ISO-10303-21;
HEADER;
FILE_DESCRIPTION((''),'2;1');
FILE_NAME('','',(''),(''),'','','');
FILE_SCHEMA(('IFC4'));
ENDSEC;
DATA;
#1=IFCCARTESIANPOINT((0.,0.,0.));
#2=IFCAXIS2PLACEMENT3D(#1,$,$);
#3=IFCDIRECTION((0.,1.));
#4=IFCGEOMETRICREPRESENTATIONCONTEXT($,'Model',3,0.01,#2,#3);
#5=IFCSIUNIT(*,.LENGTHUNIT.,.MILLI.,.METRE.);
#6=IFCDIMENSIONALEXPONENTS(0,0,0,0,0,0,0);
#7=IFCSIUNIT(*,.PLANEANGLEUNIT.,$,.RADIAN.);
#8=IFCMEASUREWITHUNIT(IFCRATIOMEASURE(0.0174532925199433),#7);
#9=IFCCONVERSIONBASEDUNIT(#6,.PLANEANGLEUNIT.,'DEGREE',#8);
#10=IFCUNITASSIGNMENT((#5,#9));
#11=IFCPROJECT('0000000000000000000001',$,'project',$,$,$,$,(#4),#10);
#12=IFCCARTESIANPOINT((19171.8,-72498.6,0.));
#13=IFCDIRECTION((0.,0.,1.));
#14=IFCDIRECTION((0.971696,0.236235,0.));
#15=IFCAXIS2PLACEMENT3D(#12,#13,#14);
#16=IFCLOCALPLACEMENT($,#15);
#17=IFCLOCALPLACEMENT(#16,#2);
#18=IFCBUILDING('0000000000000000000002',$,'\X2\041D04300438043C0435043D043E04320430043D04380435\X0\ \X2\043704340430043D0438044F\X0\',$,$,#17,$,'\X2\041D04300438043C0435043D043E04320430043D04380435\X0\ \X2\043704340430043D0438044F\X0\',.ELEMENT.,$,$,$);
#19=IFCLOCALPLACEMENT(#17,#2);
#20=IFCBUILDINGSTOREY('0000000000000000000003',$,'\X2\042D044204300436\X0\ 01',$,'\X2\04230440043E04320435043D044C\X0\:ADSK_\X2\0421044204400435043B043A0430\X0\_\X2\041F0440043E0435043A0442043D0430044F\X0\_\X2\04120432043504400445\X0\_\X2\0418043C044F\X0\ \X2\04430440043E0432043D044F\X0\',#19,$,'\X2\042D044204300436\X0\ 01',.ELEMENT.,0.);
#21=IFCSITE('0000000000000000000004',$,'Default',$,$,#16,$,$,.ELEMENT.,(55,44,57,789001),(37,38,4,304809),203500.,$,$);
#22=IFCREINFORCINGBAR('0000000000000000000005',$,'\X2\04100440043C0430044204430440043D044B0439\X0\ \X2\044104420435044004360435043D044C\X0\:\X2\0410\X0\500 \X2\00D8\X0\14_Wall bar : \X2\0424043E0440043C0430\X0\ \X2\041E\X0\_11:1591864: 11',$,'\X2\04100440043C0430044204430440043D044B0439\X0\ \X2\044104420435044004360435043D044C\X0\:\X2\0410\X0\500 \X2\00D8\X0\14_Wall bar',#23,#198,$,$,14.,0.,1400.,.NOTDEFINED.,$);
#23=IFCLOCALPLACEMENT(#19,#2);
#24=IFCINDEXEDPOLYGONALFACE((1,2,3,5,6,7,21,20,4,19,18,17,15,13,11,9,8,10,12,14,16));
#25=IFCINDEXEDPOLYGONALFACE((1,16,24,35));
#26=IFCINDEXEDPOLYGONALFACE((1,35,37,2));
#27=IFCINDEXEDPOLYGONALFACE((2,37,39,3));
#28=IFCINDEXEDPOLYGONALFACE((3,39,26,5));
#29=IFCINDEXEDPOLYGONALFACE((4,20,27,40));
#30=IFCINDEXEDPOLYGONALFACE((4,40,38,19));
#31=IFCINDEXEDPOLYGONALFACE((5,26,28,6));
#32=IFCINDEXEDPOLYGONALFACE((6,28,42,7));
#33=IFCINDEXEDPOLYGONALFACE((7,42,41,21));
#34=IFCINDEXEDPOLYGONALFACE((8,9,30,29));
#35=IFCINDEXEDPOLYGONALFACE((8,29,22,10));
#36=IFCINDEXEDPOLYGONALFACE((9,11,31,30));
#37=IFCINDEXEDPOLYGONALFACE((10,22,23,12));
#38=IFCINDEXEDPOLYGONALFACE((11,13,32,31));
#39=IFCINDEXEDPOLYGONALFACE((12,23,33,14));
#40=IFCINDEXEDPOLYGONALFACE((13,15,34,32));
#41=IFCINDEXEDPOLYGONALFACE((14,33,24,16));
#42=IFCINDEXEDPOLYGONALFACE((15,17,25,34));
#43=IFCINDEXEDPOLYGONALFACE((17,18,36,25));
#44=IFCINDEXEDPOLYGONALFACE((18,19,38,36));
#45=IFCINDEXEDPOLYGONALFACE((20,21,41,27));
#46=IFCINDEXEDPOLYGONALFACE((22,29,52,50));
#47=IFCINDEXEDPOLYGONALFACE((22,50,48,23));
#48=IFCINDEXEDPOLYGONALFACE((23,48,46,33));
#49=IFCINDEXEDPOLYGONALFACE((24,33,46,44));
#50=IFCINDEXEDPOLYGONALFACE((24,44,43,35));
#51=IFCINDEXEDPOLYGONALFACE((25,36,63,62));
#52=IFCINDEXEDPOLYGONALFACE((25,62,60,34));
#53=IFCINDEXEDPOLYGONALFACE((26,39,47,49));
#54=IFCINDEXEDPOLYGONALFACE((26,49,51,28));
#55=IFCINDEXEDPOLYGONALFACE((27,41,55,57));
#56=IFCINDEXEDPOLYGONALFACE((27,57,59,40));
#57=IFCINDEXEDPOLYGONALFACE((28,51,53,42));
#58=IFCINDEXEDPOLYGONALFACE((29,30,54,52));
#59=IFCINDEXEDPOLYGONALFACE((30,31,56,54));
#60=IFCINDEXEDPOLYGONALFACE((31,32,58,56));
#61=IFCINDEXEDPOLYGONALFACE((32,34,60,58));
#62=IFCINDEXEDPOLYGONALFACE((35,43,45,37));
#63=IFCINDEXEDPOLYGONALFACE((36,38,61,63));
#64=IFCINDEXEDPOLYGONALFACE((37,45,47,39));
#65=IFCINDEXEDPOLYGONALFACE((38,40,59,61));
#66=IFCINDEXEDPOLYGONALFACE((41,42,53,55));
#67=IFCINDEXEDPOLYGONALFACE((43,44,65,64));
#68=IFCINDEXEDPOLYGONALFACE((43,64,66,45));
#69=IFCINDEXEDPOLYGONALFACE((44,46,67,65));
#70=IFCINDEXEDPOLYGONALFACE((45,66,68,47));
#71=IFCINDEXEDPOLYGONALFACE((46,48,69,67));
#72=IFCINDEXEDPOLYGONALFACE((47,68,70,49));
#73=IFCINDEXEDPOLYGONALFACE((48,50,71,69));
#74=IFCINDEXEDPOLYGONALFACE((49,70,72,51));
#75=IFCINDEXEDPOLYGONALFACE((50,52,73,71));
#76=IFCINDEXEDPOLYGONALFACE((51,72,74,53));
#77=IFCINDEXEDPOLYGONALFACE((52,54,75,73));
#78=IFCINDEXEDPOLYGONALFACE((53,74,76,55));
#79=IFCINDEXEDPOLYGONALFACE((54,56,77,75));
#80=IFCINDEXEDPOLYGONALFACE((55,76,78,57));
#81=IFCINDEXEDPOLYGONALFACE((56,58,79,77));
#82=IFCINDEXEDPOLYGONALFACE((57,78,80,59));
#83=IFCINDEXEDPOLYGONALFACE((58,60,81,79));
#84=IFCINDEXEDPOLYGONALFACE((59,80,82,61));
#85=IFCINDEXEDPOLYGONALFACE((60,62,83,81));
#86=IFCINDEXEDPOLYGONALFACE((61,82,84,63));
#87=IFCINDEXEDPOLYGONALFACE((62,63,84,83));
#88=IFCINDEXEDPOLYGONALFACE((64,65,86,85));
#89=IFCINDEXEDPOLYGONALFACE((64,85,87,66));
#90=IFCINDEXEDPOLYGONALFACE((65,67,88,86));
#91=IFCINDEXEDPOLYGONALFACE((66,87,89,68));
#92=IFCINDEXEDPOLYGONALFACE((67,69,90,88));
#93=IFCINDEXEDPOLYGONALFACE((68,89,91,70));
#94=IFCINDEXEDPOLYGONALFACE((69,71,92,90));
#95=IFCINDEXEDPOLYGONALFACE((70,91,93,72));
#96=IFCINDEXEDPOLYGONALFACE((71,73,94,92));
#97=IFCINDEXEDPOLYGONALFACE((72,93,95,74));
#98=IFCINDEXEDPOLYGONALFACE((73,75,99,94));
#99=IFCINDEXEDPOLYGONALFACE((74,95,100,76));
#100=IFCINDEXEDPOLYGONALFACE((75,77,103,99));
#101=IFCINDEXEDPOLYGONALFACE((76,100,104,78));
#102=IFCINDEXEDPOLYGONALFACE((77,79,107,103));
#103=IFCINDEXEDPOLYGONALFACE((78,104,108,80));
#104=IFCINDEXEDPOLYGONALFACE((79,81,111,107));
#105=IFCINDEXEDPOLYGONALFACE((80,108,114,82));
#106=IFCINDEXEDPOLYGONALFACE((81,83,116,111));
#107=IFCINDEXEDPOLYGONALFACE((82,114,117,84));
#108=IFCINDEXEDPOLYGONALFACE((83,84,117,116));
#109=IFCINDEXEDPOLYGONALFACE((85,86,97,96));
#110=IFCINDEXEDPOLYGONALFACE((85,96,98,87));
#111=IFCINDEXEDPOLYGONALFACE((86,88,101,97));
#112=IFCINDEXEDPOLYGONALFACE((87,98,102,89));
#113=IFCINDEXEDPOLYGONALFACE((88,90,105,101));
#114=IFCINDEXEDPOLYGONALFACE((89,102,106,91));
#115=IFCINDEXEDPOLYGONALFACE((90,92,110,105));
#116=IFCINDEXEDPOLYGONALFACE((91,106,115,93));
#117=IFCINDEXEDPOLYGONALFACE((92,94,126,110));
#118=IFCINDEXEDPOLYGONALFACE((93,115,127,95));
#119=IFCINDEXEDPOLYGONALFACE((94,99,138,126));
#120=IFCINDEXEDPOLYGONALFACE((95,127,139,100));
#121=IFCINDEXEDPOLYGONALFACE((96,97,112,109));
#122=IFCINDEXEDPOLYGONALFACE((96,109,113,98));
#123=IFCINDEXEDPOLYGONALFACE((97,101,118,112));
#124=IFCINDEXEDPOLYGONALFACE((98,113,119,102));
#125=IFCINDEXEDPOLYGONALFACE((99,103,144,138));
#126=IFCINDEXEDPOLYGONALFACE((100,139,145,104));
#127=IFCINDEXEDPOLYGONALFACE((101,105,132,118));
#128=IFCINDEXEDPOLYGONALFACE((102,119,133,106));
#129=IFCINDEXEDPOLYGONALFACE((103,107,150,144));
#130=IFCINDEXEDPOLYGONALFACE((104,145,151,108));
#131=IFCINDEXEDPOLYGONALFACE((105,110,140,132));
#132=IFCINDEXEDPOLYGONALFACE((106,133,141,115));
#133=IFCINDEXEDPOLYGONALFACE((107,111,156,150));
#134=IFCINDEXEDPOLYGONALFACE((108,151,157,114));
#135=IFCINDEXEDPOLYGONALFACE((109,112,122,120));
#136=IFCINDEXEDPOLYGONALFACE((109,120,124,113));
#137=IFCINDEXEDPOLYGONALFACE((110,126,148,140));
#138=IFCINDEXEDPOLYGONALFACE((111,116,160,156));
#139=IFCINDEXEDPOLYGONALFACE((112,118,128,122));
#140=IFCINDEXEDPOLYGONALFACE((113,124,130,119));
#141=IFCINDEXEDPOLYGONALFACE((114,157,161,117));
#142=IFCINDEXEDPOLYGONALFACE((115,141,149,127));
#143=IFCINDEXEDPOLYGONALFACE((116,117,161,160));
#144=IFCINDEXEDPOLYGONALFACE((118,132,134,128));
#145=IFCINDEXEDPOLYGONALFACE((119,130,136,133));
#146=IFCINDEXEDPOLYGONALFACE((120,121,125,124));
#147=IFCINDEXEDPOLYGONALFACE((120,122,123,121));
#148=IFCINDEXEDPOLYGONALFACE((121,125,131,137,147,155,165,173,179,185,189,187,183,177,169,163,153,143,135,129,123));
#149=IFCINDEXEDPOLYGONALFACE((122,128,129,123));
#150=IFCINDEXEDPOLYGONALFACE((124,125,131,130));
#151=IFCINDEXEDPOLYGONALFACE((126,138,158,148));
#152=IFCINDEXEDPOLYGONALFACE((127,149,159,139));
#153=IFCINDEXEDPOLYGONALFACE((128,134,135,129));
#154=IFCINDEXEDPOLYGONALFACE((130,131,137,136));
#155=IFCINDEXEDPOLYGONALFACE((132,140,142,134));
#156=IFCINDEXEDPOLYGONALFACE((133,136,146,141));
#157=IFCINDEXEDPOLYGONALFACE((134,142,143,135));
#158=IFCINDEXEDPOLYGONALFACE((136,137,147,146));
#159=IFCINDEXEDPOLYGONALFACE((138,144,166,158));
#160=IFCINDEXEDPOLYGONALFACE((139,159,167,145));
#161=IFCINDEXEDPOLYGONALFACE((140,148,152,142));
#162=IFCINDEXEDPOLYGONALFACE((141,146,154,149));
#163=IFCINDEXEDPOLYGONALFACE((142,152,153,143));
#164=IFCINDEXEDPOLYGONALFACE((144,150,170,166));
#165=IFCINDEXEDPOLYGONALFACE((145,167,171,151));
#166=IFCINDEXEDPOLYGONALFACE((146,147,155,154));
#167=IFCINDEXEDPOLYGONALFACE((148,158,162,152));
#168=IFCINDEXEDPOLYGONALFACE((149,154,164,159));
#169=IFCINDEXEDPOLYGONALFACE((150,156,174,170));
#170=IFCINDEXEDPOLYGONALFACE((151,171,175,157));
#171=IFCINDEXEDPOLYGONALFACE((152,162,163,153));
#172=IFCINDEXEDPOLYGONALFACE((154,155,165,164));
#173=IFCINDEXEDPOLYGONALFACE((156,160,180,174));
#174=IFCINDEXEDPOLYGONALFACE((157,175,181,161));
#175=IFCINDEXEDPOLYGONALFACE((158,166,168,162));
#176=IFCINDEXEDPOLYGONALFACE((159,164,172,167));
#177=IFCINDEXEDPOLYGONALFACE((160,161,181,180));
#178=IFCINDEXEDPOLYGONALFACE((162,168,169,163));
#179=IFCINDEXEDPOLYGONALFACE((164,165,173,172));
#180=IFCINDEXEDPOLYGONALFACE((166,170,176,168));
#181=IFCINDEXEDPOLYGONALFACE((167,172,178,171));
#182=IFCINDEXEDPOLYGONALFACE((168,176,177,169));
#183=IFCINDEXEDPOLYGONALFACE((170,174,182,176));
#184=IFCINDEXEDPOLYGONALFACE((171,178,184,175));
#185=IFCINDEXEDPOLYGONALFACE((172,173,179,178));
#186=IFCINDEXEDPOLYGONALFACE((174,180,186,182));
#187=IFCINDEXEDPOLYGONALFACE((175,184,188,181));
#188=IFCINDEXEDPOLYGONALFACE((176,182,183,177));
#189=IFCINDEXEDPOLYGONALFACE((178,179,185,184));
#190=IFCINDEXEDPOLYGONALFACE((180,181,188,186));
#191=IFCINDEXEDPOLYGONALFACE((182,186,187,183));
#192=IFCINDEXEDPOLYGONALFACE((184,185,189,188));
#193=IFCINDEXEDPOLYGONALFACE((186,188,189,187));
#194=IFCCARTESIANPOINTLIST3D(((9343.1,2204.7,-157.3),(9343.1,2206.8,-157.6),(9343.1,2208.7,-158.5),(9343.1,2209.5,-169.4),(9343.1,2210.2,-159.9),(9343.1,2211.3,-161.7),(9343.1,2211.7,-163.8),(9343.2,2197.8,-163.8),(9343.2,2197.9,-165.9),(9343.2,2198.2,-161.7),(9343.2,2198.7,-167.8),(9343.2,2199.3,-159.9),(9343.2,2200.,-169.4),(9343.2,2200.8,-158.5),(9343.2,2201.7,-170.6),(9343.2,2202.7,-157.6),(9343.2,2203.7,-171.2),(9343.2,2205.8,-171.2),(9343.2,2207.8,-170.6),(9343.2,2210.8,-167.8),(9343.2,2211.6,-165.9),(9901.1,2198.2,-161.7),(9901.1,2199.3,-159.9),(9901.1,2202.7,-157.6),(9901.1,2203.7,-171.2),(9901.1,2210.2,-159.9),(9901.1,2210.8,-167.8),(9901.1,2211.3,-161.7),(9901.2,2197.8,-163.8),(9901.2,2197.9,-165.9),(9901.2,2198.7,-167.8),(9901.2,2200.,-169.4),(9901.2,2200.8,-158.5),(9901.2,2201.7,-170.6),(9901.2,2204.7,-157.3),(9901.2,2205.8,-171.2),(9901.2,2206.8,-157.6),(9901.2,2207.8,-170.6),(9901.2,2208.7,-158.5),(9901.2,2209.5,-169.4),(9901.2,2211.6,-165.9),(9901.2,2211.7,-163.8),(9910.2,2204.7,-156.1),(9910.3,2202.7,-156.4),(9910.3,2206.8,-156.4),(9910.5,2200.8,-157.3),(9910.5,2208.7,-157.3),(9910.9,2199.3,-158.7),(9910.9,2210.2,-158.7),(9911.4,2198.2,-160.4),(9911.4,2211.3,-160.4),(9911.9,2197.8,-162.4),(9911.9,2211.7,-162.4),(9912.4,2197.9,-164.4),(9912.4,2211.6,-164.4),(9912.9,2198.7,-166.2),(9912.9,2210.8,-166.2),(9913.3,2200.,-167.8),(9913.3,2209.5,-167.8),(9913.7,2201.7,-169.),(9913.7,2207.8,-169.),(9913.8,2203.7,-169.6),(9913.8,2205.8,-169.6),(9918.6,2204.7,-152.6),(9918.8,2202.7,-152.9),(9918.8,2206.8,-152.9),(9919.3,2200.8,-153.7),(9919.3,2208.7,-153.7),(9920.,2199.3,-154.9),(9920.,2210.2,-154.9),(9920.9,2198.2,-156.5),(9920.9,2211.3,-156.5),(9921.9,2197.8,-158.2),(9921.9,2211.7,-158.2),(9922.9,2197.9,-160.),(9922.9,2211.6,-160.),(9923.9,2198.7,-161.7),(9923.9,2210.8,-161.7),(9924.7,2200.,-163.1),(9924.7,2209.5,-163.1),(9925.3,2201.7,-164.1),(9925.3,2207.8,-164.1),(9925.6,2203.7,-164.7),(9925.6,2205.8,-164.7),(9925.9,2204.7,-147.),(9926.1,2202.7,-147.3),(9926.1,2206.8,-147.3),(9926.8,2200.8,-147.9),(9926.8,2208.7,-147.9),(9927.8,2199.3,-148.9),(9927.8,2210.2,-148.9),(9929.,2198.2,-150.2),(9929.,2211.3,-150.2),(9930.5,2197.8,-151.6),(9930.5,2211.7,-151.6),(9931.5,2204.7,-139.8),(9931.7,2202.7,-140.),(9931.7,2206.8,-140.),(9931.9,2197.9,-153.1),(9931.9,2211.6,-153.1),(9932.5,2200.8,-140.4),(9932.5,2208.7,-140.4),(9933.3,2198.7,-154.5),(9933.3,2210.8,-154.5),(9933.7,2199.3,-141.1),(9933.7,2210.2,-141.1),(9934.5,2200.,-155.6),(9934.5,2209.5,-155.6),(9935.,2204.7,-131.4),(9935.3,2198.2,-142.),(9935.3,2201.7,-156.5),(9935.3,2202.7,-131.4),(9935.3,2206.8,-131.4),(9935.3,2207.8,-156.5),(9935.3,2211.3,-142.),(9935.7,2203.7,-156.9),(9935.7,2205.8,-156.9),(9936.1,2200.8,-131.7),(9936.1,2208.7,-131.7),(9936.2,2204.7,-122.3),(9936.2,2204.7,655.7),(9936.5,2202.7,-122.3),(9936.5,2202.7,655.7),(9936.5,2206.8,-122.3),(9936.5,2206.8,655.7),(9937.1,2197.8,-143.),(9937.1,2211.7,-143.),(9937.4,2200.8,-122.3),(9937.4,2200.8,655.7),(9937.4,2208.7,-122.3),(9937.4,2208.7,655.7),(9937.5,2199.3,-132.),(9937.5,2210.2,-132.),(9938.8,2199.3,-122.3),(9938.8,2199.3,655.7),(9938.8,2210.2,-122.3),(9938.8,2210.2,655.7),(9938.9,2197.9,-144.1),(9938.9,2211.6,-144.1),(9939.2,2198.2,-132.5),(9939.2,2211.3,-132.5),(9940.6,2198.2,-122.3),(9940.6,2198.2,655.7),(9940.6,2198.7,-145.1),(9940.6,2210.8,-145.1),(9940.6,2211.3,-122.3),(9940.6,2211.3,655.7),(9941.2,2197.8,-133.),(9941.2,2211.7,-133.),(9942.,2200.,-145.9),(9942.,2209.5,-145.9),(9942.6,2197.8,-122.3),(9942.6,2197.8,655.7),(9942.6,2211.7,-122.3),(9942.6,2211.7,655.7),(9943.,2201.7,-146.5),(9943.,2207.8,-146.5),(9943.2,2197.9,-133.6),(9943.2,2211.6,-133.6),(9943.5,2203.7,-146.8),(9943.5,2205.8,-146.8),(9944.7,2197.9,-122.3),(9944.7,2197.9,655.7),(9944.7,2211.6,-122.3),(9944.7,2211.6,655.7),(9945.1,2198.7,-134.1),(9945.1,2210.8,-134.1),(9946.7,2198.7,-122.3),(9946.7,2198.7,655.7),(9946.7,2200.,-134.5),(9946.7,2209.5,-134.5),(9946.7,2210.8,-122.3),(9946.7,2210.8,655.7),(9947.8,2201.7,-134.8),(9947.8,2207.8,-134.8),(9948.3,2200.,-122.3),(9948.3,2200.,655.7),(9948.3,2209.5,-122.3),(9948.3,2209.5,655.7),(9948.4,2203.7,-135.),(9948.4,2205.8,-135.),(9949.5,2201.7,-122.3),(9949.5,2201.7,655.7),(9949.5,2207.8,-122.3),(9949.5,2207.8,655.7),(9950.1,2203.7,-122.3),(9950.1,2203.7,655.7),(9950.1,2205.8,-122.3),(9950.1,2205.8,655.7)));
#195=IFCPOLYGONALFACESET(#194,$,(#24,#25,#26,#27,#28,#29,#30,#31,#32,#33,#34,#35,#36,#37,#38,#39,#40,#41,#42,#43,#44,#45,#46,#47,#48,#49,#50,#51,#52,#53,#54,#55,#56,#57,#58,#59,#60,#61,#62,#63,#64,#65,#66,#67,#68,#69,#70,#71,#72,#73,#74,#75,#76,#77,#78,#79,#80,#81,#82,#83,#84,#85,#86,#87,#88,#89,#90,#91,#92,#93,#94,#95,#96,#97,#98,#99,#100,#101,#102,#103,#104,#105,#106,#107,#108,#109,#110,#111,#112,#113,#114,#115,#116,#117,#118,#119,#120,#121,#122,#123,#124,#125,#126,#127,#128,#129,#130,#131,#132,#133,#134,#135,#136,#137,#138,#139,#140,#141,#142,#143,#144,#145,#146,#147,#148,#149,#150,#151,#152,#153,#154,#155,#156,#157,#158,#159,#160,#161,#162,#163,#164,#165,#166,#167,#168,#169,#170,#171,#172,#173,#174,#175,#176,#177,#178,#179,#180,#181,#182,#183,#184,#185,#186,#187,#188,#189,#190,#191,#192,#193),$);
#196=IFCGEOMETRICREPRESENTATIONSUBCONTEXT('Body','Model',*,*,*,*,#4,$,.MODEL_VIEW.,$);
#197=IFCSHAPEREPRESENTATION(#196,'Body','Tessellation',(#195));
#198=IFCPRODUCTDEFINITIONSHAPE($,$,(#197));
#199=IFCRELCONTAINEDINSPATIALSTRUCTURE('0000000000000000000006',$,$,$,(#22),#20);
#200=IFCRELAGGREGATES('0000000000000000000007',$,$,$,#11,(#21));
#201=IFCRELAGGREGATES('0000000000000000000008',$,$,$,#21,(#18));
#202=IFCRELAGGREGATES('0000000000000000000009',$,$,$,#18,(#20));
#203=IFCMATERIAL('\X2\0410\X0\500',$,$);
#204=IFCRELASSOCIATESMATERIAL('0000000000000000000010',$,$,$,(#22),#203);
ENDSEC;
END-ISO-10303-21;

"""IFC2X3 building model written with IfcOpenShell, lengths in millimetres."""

from ifc_helpers import new_model, entity, si_unit, converted_unit, direction, frame, origin, place, context, subcontext, project, spatial, material, element, save


model = new_model("IFC2X3")

# Units and contexts
model_context = context("Model", 3, precision=0.01, world=origin(), true_north=direction((0.0, 1.0)))
body_context = subcontext(model_context, "Body", "Model", "MODEL_VIEW")
ifc_project = project(units=[si_unit("LENGTHUNIT", "METRE", prefix="MILLI"), converted_unit("PLANEANGLEUNIT", "DEGREE", entity("IfcRatioMeasure", 0.0174532925199433), si_unit("PLANEANGLEUNIT", "RADIAN"), dimensions=[0, 0, 0, 0, 0, 0, 0])], contexts=[model_context])

# Site, building, storey
site_placement = place(None, frame((19171.8, -72498.6, 0.0), z_axis=(0.0, 0.0, 1.0), x_axis=(0.971696, 0.236235, 0.0)))
site = spatial("IfcSite", under=ifc_project, at=site_placement, Name="Default", CompositionType="ELEMENT", RefLatitude=(55, 44, 57, 789001), RefLongitude=(37, 38, 4, 304809), RefElevation=203500.0)
building_placement = place(site_placement, origin())
building = spatial("IfcBuilding", under=site, at=building_placement, Name="Наименование здания", LongName="Наименование здания", CompositionType="ELEMENT")
storey_placement = place(building_placement, origin())
storey = spatial("IfcBuildingStorey", under=building, at=storey_placement, Name="Этаж 01", ObjectType="Уровень:ADSK_Стрелка_Проектная_Вверх_Имя уровня", LongName="Этаж 01", CompositionType="ELEMENT", Elevation=0.0)

# Reinforcing bar
ifc_material = material(Name="А500")
placement = place(storey_placement, origin())
element("IfcReinforcingBar", 1, at=placement, inside=storey, material=ifc_material, Name="Арматурный стержень:А500 Ø14_Wall bar : Форма О_11:1591864: 11", ObjectType="Арматурный стержень:А500 Ø14_Wall bar", BarLength=1400.0, BarRole="NOTDEFINED", CrossSectionArea=0.0, NominalDiameter=14.0, context=body_context, shape_type="AdvancedSweptSolid", body=[
    entity("IfcSweptDiskSolid", entity("IfcCompositeCurve", [entity("IfcCompositeCurveSegment", "CONTINUOUS", True, entity("IfcPolyline", [entity("IfcCartesianPoint", [9943.1, 2204.7, 655.7]), entity("IfcCartesianPoint", [9943.1, 2204.7, -122.3])])), entity("IfcCompositeCurveSegment", "CONTINUOUS", True, entity("IfcTrimmedCurve", entity("IfcCircle", entity("IfcAxis2Placement3D", entity("IfcCartesianPoint", [9901.1, 2204.7, -122.3]), entity("IfcDirection", [0.0, 1.0, 0.0]), entity("IfcDirection", [0.0, 0.0, -1.0])), 42.0), [entity("IfcParameterValue", 270.0)], [entity("IfcParameterValue", 360.0)], True, "PARAMETER")), entity("IfcCompositeCurveSegment", "CONTINUOUS", True, entity("IfcPolyline", [entity("IfcCartesianPoint", [9901.1, 2204.7, -164.3]), entity("IfcCartesianPoint", [9343.1, 2204.7, -164.3])]))], False), 7.0, None, 0.0, 92.0),
])

save(model, "model.ifc")
